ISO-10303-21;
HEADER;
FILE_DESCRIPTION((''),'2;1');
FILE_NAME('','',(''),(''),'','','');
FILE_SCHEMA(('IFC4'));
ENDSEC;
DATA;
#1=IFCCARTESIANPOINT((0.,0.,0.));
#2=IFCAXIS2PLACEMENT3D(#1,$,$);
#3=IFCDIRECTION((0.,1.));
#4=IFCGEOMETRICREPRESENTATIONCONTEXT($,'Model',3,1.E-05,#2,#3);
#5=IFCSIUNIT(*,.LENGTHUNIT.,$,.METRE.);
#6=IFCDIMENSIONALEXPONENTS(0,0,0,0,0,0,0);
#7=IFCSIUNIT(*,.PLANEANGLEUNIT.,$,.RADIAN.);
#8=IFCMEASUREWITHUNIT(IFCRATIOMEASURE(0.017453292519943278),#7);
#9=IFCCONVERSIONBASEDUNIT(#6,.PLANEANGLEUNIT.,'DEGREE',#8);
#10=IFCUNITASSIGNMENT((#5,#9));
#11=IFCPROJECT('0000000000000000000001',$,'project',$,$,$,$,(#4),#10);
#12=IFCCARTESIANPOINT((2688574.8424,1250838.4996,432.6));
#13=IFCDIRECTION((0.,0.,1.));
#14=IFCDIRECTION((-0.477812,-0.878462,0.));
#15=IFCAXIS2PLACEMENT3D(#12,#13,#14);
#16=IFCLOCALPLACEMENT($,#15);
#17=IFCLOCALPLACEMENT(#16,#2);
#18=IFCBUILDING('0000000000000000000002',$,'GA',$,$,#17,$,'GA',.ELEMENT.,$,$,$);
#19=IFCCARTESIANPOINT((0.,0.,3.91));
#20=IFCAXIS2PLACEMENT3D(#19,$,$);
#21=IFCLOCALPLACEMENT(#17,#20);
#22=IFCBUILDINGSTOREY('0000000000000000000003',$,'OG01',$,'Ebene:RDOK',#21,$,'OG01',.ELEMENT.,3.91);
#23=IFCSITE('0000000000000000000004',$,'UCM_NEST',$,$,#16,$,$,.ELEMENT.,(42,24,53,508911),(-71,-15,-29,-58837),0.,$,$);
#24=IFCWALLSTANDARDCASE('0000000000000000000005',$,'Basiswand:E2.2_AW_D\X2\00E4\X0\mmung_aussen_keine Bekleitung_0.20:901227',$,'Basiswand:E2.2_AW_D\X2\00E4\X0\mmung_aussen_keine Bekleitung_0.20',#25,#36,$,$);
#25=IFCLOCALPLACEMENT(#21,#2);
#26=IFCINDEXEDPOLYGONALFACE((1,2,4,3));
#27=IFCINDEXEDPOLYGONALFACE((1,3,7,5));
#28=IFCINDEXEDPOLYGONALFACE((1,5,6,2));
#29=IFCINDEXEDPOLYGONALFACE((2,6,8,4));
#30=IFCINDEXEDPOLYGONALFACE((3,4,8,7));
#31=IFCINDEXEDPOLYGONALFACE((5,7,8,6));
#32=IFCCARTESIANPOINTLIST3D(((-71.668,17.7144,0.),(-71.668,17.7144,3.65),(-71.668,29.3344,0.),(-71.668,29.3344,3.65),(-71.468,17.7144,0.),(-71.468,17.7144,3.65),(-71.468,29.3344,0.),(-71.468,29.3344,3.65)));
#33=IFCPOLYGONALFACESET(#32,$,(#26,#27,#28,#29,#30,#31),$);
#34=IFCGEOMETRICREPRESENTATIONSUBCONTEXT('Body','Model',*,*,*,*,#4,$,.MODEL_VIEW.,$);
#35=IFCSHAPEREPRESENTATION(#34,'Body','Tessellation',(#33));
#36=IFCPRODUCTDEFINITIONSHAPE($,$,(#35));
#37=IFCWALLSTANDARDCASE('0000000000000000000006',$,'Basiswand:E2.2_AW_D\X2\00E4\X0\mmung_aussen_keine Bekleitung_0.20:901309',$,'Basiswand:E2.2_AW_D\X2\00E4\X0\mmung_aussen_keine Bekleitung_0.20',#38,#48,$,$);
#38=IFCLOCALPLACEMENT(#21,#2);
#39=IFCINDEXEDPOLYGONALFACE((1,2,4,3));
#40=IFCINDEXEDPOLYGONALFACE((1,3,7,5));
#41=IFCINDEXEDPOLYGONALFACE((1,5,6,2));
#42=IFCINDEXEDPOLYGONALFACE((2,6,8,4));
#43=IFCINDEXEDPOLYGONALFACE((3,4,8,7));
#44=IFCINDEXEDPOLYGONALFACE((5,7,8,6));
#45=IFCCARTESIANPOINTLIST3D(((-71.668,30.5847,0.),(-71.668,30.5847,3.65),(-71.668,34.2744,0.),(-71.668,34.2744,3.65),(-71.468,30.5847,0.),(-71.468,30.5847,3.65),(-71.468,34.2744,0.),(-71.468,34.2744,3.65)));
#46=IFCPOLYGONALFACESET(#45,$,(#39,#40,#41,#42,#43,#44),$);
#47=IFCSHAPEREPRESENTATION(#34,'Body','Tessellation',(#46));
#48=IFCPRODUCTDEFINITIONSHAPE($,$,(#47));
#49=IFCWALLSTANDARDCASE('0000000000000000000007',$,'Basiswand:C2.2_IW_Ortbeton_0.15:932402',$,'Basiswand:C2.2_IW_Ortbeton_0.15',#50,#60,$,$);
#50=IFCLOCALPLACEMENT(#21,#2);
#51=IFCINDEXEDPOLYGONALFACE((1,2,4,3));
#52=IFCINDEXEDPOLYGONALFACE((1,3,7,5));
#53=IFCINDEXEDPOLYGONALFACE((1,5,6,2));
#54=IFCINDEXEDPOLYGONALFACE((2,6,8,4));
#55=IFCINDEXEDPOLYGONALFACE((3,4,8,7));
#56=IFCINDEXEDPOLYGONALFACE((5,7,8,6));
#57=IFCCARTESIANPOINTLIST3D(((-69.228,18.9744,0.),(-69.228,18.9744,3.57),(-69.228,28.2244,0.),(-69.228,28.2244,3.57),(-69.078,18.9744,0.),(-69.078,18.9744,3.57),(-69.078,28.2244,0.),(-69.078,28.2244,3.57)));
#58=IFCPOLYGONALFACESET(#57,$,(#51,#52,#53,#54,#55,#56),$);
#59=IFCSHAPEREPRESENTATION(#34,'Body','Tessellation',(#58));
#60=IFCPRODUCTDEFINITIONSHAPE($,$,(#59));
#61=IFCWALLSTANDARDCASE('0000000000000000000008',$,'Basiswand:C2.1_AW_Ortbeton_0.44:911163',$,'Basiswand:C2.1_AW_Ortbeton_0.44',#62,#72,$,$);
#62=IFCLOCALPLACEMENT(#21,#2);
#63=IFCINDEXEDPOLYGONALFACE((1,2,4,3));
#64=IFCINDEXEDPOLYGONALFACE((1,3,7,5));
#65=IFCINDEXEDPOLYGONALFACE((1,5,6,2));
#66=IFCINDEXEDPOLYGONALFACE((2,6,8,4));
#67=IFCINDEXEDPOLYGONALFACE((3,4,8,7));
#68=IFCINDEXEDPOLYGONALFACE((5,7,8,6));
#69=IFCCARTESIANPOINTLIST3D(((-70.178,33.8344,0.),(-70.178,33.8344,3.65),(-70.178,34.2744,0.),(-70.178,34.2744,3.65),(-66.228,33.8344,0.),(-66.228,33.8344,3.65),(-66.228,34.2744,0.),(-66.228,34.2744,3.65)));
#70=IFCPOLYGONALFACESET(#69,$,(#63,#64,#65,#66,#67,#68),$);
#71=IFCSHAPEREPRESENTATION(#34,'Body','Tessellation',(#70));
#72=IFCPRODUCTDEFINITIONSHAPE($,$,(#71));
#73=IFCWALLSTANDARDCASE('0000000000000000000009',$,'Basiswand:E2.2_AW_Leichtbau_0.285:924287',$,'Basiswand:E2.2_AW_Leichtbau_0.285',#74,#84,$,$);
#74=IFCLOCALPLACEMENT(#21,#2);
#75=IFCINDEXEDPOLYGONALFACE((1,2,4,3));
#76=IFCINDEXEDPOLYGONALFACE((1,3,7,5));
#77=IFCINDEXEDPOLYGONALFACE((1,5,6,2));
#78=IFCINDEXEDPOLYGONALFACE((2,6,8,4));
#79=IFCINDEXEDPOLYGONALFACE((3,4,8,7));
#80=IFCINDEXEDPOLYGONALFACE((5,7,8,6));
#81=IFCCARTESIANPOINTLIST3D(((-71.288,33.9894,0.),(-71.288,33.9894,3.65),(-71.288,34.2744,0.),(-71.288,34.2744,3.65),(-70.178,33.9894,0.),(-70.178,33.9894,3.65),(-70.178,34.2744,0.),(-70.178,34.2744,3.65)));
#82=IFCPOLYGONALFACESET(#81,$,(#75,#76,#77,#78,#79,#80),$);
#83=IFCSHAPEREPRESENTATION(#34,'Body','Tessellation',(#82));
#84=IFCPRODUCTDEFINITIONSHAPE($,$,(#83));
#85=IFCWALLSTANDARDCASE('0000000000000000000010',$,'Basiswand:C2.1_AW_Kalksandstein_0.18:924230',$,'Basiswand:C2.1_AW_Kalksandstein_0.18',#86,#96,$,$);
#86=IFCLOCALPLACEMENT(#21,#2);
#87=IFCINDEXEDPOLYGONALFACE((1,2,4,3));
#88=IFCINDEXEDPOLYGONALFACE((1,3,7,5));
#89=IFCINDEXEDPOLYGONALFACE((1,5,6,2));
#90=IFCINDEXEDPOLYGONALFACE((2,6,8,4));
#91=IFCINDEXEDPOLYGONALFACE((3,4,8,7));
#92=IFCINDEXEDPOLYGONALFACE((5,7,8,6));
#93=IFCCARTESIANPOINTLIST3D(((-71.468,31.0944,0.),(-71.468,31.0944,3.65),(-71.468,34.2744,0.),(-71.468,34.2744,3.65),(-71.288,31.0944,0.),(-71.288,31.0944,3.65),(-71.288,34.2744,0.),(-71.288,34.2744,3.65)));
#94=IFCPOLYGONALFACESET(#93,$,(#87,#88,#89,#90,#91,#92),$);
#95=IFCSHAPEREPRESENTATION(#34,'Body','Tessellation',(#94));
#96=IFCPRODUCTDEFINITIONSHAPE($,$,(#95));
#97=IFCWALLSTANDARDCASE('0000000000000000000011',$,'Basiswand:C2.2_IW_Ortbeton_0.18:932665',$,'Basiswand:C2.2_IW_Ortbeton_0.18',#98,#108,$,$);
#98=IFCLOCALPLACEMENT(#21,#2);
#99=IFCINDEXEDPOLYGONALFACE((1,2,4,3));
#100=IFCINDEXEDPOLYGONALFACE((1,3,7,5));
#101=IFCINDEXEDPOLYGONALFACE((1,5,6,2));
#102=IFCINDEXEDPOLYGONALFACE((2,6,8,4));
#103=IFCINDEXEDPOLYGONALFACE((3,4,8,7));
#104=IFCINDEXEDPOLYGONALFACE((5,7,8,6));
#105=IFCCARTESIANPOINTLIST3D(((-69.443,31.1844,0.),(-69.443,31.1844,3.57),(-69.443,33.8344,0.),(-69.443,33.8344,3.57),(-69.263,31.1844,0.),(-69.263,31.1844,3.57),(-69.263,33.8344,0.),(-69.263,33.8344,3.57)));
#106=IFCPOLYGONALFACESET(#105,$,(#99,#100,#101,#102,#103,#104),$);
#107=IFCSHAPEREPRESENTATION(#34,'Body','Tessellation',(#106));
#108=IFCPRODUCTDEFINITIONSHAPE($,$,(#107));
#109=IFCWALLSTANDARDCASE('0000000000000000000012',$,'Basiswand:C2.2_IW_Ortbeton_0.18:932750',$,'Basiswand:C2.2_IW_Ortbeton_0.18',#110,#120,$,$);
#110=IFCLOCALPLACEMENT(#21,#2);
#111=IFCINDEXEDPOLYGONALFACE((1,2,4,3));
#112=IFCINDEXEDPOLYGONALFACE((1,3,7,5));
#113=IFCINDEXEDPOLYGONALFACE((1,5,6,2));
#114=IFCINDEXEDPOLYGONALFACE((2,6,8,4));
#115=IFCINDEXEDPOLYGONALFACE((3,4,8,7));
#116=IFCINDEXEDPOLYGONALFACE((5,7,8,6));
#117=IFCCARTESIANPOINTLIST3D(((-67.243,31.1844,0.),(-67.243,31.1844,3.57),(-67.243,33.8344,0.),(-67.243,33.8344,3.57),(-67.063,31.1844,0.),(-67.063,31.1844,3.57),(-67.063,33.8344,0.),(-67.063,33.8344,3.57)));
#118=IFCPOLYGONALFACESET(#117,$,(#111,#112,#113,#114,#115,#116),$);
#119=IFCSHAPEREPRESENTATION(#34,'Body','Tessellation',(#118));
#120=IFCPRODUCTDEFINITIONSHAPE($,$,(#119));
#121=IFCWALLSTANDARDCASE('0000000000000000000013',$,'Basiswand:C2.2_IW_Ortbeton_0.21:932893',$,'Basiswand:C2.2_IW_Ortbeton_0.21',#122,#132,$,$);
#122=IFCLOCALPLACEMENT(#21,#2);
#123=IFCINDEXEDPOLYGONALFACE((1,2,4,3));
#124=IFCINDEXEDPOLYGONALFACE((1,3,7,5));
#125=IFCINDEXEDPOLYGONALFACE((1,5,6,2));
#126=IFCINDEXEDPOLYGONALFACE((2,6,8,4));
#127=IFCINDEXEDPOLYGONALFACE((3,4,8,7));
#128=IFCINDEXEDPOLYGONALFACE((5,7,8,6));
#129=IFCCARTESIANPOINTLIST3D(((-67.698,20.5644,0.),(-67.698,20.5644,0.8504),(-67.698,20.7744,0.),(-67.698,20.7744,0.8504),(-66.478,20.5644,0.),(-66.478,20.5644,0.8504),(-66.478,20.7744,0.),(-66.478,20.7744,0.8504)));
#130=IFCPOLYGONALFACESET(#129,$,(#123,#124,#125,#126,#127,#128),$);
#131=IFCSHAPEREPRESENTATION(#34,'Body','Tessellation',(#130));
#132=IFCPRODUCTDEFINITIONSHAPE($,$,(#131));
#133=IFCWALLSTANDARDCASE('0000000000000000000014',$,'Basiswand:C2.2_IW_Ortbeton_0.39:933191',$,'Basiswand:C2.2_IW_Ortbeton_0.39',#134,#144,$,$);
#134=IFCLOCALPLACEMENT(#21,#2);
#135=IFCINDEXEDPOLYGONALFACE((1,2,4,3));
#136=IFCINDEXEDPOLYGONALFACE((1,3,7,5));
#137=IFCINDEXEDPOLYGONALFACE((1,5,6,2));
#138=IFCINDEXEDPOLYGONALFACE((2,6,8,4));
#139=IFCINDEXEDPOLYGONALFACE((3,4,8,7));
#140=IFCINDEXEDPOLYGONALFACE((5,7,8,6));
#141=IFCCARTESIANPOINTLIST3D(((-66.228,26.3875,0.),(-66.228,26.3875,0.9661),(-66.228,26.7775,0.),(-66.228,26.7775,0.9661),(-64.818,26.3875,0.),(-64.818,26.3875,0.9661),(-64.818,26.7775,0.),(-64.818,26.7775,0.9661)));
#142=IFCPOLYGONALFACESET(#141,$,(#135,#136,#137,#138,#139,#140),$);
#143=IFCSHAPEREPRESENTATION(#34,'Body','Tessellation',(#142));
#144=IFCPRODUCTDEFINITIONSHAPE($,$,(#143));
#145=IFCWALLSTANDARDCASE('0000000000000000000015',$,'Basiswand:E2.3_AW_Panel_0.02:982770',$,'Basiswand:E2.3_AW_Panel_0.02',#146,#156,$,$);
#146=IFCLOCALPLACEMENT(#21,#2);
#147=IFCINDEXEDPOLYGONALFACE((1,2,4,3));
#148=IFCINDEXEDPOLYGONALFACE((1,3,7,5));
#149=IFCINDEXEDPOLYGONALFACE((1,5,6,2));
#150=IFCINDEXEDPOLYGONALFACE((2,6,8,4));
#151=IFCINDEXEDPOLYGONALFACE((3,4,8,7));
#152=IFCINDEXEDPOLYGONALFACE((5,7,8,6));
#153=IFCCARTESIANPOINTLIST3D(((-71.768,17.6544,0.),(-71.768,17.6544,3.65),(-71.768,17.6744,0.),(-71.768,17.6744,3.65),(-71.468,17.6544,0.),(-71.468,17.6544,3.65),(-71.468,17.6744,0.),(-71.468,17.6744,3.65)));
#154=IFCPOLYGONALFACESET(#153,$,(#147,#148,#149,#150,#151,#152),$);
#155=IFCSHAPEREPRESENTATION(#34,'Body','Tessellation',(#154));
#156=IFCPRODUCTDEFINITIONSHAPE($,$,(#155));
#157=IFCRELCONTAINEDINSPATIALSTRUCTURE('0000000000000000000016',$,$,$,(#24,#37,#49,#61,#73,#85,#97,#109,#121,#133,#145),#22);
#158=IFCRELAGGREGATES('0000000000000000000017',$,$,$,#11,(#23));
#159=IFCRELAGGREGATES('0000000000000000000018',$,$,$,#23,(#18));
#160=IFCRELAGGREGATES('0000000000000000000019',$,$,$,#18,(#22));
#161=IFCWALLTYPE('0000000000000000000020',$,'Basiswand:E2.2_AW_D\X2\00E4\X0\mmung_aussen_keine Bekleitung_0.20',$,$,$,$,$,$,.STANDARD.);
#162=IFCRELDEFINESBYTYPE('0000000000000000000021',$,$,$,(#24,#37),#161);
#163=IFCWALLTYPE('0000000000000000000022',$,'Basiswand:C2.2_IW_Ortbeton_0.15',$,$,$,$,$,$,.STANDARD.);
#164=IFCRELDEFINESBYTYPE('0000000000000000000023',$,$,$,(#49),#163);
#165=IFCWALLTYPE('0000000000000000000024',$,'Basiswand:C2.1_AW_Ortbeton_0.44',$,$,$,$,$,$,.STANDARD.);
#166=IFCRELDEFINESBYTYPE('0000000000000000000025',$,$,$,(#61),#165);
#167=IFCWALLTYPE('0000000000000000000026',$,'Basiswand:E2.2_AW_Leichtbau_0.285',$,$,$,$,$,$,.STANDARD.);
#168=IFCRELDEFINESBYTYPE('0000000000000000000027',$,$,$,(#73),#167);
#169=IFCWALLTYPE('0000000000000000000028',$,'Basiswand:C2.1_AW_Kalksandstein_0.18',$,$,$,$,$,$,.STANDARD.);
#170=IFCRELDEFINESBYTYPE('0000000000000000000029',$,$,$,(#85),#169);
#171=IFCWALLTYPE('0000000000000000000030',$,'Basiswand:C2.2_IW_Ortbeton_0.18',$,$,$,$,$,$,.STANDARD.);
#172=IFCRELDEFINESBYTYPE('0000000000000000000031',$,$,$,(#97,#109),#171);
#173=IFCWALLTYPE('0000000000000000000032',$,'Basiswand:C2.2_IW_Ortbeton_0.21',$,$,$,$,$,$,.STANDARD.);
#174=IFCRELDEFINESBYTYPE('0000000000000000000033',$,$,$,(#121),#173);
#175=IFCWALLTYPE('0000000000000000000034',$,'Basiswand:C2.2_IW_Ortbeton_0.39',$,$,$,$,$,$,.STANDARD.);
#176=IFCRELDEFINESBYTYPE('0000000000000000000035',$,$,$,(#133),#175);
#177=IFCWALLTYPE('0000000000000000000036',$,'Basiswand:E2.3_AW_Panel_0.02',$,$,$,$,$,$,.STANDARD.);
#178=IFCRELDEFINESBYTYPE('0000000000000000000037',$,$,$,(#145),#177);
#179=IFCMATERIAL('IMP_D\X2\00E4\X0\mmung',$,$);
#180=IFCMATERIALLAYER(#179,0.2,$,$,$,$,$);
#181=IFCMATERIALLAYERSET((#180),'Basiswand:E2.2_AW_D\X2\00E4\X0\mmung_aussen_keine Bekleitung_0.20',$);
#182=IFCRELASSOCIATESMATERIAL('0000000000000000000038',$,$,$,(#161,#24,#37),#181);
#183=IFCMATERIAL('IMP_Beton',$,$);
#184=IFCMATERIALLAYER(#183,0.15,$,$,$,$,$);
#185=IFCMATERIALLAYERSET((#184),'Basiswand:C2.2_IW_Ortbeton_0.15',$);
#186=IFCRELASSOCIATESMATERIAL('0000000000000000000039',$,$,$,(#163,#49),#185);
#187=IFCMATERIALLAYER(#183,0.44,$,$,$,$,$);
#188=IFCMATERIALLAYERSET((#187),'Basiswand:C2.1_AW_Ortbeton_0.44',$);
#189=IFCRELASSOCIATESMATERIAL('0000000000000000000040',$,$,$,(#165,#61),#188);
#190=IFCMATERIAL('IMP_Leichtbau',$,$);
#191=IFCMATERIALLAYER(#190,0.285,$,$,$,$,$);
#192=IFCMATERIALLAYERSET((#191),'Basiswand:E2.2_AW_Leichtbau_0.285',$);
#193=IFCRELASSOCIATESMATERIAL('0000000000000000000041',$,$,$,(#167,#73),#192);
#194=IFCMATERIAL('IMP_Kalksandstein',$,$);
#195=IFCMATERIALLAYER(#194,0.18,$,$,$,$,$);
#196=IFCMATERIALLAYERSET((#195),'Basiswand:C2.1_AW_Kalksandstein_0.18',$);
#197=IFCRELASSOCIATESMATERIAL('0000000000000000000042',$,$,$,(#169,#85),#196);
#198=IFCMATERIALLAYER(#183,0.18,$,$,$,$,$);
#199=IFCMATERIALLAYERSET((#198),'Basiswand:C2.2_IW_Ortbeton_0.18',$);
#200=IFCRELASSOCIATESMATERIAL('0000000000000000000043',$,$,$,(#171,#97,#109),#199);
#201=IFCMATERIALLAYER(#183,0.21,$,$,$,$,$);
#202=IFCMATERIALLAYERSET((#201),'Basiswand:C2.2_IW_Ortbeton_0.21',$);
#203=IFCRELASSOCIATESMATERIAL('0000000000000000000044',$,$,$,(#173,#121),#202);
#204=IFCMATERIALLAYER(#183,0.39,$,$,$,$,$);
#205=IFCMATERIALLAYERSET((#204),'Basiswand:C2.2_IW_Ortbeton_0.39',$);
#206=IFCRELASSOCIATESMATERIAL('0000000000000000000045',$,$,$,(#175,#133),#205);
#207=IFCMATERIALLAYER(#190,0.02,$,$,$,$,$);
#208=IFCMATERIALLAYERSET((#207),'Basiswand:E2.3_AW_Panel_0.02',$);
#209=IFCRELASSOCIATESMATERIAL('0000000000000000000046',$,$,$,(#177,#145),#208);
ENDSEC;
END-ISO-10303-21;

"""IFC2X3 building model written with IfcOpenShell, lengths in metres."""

from ifc_helpers import new_model, entity, si_unit, converted_unit, direction, frame, frame_2d, origin, place, context, subcontext, project, spatial, polyline, rectangle, extrude, clip, bounded_halfspace, material, layer, layer_set, layer_usage, type_object, element, save


model = new_model("IFC2X3")

# Units and contexts
model_context = context("Model", 3, precision=1e-05, world=origin(), true_north=direction((0.0, 1.0)))
body_context = subcontext(model_context, "Body", "Model", "MODEL_VIEW")
ifc_project = project(units=[si_unit("LENGTHUNIT", "METRE"), converted_unit("PLANEANGLEUNIT", "DEGREE", entity("IfcRatioMeasure", 0.017453292519943278), si_unit("PLANEANGLEUNIT", "RADIAN"), dimensions=[0, 0, 0, 0, 0, 0, 0])], contexts=[model_context])

# Site, building, storey
site_placement = place(None, frame((2688574.8424, 1250838.4996, 432.6), z_axis=(0.0, 0.0, 1.0), x_axis=(-0.477812, -0.878462, 0.0)))
site = spatial("IfcSite", under=ifc_project, at=site_placement, Name="UCM_NEST", CompositionType="ELEMENT", RefLatitude=(42, 24, 53, 508911), RefLongitude=(-71, -15, -29, -58837), RefElevation=0.0)
building_placement = place(site_placement, origin())
building = spatial("IfcBuilding", under=site, at=building_placement, Name="GA", LongName="GA", CompositionType="ELEMENT")
storey_placement = place(building_placement, frame((0.0, 0.0, 3.91)))
storey = spatial("IfcBuildingStorey", under=building, at=storey_placement, Name="OG01", ObjectType="Ebene:RDOK", LongName="OG01", CompositionType="ELEMENT", Elevation=3.91)

# Walls
ifc_material_1 = material(Name="IMP_Dämmung")
ifc_layer_1 = layer(ifc_material_1, 0.2)
ifc_layer_set_1 = layer_set([ifc_layer_1], Name="Basiswand:E2.2_AW_Dämmung_aussen_keine Bekleitung_0.20")
ifc_layer_usage_1 = layer_usage(ifc_layer_set_1, "AXIS2", "NEGATIVE", 0.1)
wall_type_1 = type_object("IfcWallType", Name="Basiswand:E2.2_AW_Dämmung_aussen_keine Bekleitung_0.20", PredefinedType="STANDARD", material=ifc_layer_set_1)
wall_1_placement = place(storey_placement, frame((-71.568, 17.7144, 0.0), z_axis=(0.0, 0.0, 1.0), x_axis=(0.0, 1.0, 0.0)))
element("IfcWallStandardCase", 1, at=wall_1_placement, inside=storey, type_object=wall_type_1, material=ifc_layer_usage_1, Name="Basiswand:E2.2_AW_Dämmung_aussen_keine Bekleitung_0.20:901227", ObjectType="Basiswand:E2.2_AW_Dämmung_aussen_keine Bekleitung_0.20", context=body_context, shape_type="SweptSolid", body=[
    extrude(rectangle(XDim=11.62, YDim=0.2, at=frame_2d((5.81, 0.0), x_axis=(-1.0, 0.0))), origin(), (0.0, 0.0, 1.0), 3.65),
])
wall_2_placement = place(storey_placement, frame((-71.568, 30.5847, 0.0), z_axis=(0.0, 0.0, 1.0), x_axis=(0.0, 1.0, 0.0)))
element("IfcWallStandardCase", 2, at=wall_2_placement, inside=storey, type_object=wall_type_1, material=ifc_layer_usage_1, Name="Basiswand:E2.2_AW_Dämmung_aussen_keine Bekleitung_0.20:901309", ObjectType="Basiswand:E2.2_AW_Dämmung_aussen_keine Bekleitung_0.20", context=body_context, shape_type="SweptSolid", body=[
    extrude(rectangle(XDim=3.6898, YDim=0.2, at=frame_2d((1.8449, 0.0), x_axis=(-1.0, 0.0))), origin(), (0.0, 0.0, 1.0), 3.65),
])

# Shared definitions
ifc_material_2 = material(Name="IMP_Beton")
ifc_layer_2 = layer(ifc_material_2, 0.15)
ifc_layer_set_2 = layer_set([ifc_layer_2], Name="Basiswand:C2.2_IW_Ortbeton_0.15")
ifc_layer_usage_2 = layer_usage(ifc_layer_set_2, "AXIS2", "NEGATIVE", 0.075)
wall_type_2 = type_object("IfcWallType", Name="Basiswand:C2.2_IW_Ortbeton_0.15", PredefinedType="STANDARD", material=ifc_layer_set_2)

# Wall
wall_3_placement = place(storey_placement, frame((-69.153, 18.9744, 0.0), z_axis=(0.0, 0.0, 1.0), x_axis=(0.0, 1.0, 0.0)))
element("IfcWallStandardCase", 3, at=wall_3_placement, inside=storey, type_object=wall_type_2, material=ifc_layer_usage_2, Name="Basiswand:C2.2_IW_Ortbeton_0.15:932402", ObjectType="Basiswand:C2.2_IW_Ortbeton_0.15", context=body_context, shape_type="Clipping", body=[
    clip(extrude(rectangle(XDim=9.25, YDim=0.15, at=frame_2d((4.625, 0.0), x_axis=(-1.0, 0.0))), origin(), (0.0, 0.0, 1.0), 3.57), bounded_halfspace(frame((0.0, -0.075, 3.57), z_axis=(0.0, 0.0, -1.0), x_axis=(-1.0, 0.0, 0.0)), True, frame((0.0, -0.075, 3.57), z_axis=(0.0, 0.0, -1.0), x_axis=(-1.0, 0.0, 0.0)), polyline([(0.0, 0.0), (0.0, 0.15), (-9.1, 0.15), (-9.25, 0.15), (-9.25, 0.0), (0.0, 0.0)]))),
])

# Wall
ifc_layer_3 = layer(ifc_material_2, 0.44)
ifc_layer_set_3 = layer_set([ifc_layer_3], Name="Basiswand:C2.1_AW_Ortbeton_0.44")
ifc_layer_usage_3 = layer_usage(ifc_layer_set_3, "AXIS2", "NEGATIVE", 0.22)
wall_type_3 = type_object("IfcWallType", Name="Basiswand:C2.1_AW_Ortbeton_0.44", PredefinedType="STANDARD", material=ifc_layer_set_3)
wall_4_placement = place(storey_placement, frame((-70.178, 34.0544, 0.0)))
element("IfcWallStandardCase", 4, at=wall_4_placement, inside=storey, type_object=wall_type_3, material=ifc_layer_usage_3, Name="Basiswand:C2.1_AW_Ortbeton_0.44:911163", ObjectType="Basiswand:C2.1_AW_Ortbeton_0.44", context=body_context, shape_type="SweptSolid", body=[
    extrude(rectangle(XDim=3.95, YDim=0.44, at=frame_2d((1.975, 0.0), x_axis=(-1.0, 0.0))), origin(), (0.0, 0.0, 1.0), 3.65),
])

# Wall
ifc_material_3 = material(Name="IMP_Leichtbau")
ifc_layer_4 = layer(ifc_material_3, 0.285)
ifc_layer_set_4 = layer_set([ifc_layer_4], Name="Basiswand:E2.2_AW_Leichtbau_0.285")
ifc_layer_usage_4 = layer_usage(ifc_layer_set_4, "AXIS2", "NEGATIVE", 0.1425)
wall_type_4 = type_object("IfcWallType", Name="Basiswand:E2.2_AW_Leichtbau_0.285", PredefinedType="STANDARD", material=ifc_layer_set_4)
wall_5_placement = place(storey_placement, frame((-71.288, 34.1319, 0.0)))
element("IfcWallStandardCase", 5, at=wall_5_placement, inside=storey, type_object=wall_type_4, material=ifc_layer_usage_4, Name="Basiswand:E2.2_AW_Leichtbau_0.285:924287", ObjectType="Basiswand:E2.2_AW_Leichtbau_0.285", context=body_context, shape_type="SweptSolid", body=[
    extrude(rectangle(XDim=1.11, YDim=0.285, at=frame_2d((0.555, 0.0), x_axis=(-1.0, 0.0))), origin(), (0.0, 0.0, 1.0), 3.65),
])

# Shared definitions
ifc_material_4 = material(Name="IMP_Kalksandstein")
ifc_layer_5 = layer(ifc_material_4, 0.18)
ifc_layer_set_5 = layer_set([ifc_layer_5], Name="Basiswand:C2.1_AW_Kalksandstein_0.18")
ifc_layer_usage_5 = layer_usage(ifc_layer_set_5, "AXIS2", "NEGATIVE", 0.09)
wall_type_5 = type_object("IfcWallType", Name="Basiswand:C2.1_AW_Kalksandstein_0.18", PredefinedType="STANDARD", material=ifc_layer_set_5)

# Wall
wall_6_placement = place(storey_placement, frame((-71.378, 31.0944, 0.0), z_axis=(0.0, 0.0, 1.0), x_axis=(0.0, 1.0, 0.0)))
element("IfcWallStandardCase", 6, at=wall_6_placement, inside=storey, type_object=wall_type_5, material=ifc_layer_usage_5, Name="Basiswand:C2.1_AW_Kalksandstein_0.18:924230", ObjectType="Basiswand:C2.1_AW_Kalksandstein_0.18", context=body_context, shape_type="SweptSolid", body=[
    extrude(rectangle(XDim=3.18, YDim=0.18, at=frame_2d((1.59, 0.0), x_axis=(-1.0, 0.0))), origin(), (0.0, 0.0, 1.0), 3.65),
])

# Shared definitions
ifc_layer_6 = layer(ifc_material_2, 0.18)
ifc_layer_set_6 = layer_set([ifc_layer_6], Name="Basiswand:C2.2_IW_Ortbeton_0.18")
ifc_layer_usage_6 = layer_usage(ifc_layer_set_6, "AXIS2", "NEGATIVE", 0.09)
wall_type_6 = type_object("IfcWallType", Name="Basiswand:C2.2_IW_Ortbeton_0.18", PredefinedType="STANDARD", material=ifc_layer_set_6)

# Walls
wall_7_placement = place(storey_placement, frame((-69.353, 31.1844, 0.0), z_axis=(0.0, 0.0, 1.0), x_axis=(0.0, 1.0, 0.0)))
element("IfcWallStandardCase", 7, at=wall_7_placement, inside=storey, type_object=wall_type_6, material=ifc_layer_usage_6, Name="Basiswand:C2.2_IW_Ortbeton_0.18:932665", ObjectType="Basiswand:C2.2_IW_Ortbeton_0.18", context=body_context, shape_type="Clipping", body=[
    clip(extrude(rectangle(XDim=2.65, YDim=0.18, at=frame_2d((1.325, 0.0), x_axis=(-1.0, 0.0))), origin(), (0.0, 0.0, 1.0), 3.57), bounded_halfspace(frame((0.0, -0.09, 3.57), z_axis=(0.0, 0.0, -1.0), x_axis=(-1.0, 0.0, 0.0)), True, frame((0.0, -0.09, 3.57), z_axis=(0.0, 0.0, -1.0), x_axis=(-1.0, 0.0, 0.0)), polyline([(0.0, 0.0), (0.0, 0.18), (-2.65, 0.18), (-2.65, 0.0), (0.0, 0.0)]))),
])
wall_8_placement = place(storey_placement, frame((-67.153, 31.1844, 0.0), z_axis=(0.0, 0.0, 1.0), x_axis=(0.0, 1.0, 0.0)))
element("IfcWallStandardCase", 8, at=wall_8_placement, inside=storey, type_object=wall_type_6, material=ifc_layer_usage_6, Name="Basiswand:C2.2_IW_Ortbeton_0.18:932750", ObjectType="Basiswand:C2.2_IW_Ortbeton_0.18", context=body_context, shape_type="Clipping", body=[
    clip(extrude(rectangle(XDim=2.65, YDim=0.18, at=frame_2d((1.325, 0.0), x_axis=(-1.0, 0.0))), origin(), (0.0, 0.0, 1.0), 3.57), bounded_halfspace(frame((0.0, -0.09, 3.57), z_axis=(0.0, 0.0, -1.0), x_axis=(-1.0, 0.0, 0.0)), True, frame((0.0, -0.09, 3.57), z_axis=(0.0, 0.0, -1.0), x_axis=(-1.0, 0.0, 0.0)), polyline([(0.0, 0.0), (0.0, 0.18), (-2.65, 0.18), (-2.65, 0.0), (0.0, 0.0)]))),
])

# Walls
ifc_layer_7 = layer(ifc_material_2, 0.21)
ifc_layer_set_7 = layer_set([ifc_layer_7], Name="Basiswand:C2.2_IW_Ortbeton_0.21")
ifc_layer_usage_7 = layer_usage(ifc_layer_set_7, "AXIS2", "NEGATIVE", 0.105)
wall_type_7 = type_object("IfcWallType", Name="Basiswand:C2.2_IW_Ortbeton_0.21", PredefinedType="STANDARD", material=ifc_layer_set_7)
wall_9_placement = place(storey_placement, frame((-66.478, 20.6694, 0.0), z_axis=(0.0, 0.0, 1.0), x_axis=(-1.0, 0.0, 0.0)))
element("IfcWallStandardCase", 9, at=wall_9_placement, inside=storey, type_object=wall_type_7, material=ifc_layer_usage_7, Name="Basiswand:C2.2_IW_Ortbeton_0.21:932893", ObjectType="Basiswand:C2.2_IW_Ortbeton_0.21", context=body_context, shape_type="SweptSolid", body=[
    extrude(rectangle(XDim=1.22, YDim=0.21, at=frame_2d((0.61, 0.0), x_axis=(-1.0, 0.0))), origin(), (0.0, 0.0, 1.0), 0.8504),
])
ifc_layer_8 = layer(ifc_material_2, 0.39)
ifc_layer_set_8 = layer_set([ifc_layer_8], Name="Basiswand:C2.2_IW_Ortbeton_0.39")
ifc_layer_usage_8 = layer_usage(ifc_layer_set_8, "AXIS2", "NEGATIVE", 0.195)
wall_type_8 = type_object("IfcWallType", Name="Basiswand:C2.2_IW_Ortbeton_0.39", PredefinedType="STANDARD", material=ifc_layer_set_8)
wall_10_placement = place(storey_placement, frame((-64.818, 26.5825, 0.0), z_axis=(0.0, 0.0, 1.0), x_axis=(-1.0, 0.0, 0.0)))
element("IfcWallStandardCase", 10, at=wall_10_placement, inside=storey, type_object=wall_type_8, material=ifc_layer_usage_8, Name="Basiswand:C2.2_IW_Ortbeton_0.39:933191", ObjectType="Basiswand:C2.2_IW_Ortbeton_0.39", context=body_context, shape_type="SweptSolid", body=[
    extrude(rectangle(XDim=1.41, YDim=0.39, at=frame_2d((0.705, 0.0), x_axis=(-1.0, 0.0))), origin(), (0.0, 0.0, 1.0), 0.9661),
])
ifc_layer_9 = layer(ifc_material_3, 0.02)
ifc_layer_set_9 = layer_set([ifc_layer_9], Name="Basiswand:E2.3_AW_Panel_0.02")
ifc_layer_usage_9 = layer_usage(ifc_layer_set_9, "AXIS2", "NEGATIVE", 0.01)
wall_type_9 = type_object("IfcWallType", Name="Basiswand:E2.3_AW_Panel_0.02", PredefinedType="STANDARD", material=ifc_layer_set_9)
wall_11_placement = place(storey_placement, frame((-71.468, 17.6644, 0.0), z_axis=(0.0, 0.0, 1.0), x_axis=(-1.0, 0.0, 0.0)))
element("IfcWallStandardCase", 11, at=wall_11_placement, inside=storey, type_object=wall_type_9, material=ifc_layer_usage_9, Name="Basiswand:E2.3_AW_Panel_0.02:982770", ObjectType="Basiswand:E2.3_AW_Panel_0.02", context=body_context, shape_type="SweptSolid", body=[
    extrude(rectangle(XDim=0.3, YDim=0.02, at=frame_2d((0.15, 0.0), x_axis=(-1.0, 0.0))), origin(), (0.0, 0.0, 1.0), 3.65),
])

save(model, "model.ifc")
